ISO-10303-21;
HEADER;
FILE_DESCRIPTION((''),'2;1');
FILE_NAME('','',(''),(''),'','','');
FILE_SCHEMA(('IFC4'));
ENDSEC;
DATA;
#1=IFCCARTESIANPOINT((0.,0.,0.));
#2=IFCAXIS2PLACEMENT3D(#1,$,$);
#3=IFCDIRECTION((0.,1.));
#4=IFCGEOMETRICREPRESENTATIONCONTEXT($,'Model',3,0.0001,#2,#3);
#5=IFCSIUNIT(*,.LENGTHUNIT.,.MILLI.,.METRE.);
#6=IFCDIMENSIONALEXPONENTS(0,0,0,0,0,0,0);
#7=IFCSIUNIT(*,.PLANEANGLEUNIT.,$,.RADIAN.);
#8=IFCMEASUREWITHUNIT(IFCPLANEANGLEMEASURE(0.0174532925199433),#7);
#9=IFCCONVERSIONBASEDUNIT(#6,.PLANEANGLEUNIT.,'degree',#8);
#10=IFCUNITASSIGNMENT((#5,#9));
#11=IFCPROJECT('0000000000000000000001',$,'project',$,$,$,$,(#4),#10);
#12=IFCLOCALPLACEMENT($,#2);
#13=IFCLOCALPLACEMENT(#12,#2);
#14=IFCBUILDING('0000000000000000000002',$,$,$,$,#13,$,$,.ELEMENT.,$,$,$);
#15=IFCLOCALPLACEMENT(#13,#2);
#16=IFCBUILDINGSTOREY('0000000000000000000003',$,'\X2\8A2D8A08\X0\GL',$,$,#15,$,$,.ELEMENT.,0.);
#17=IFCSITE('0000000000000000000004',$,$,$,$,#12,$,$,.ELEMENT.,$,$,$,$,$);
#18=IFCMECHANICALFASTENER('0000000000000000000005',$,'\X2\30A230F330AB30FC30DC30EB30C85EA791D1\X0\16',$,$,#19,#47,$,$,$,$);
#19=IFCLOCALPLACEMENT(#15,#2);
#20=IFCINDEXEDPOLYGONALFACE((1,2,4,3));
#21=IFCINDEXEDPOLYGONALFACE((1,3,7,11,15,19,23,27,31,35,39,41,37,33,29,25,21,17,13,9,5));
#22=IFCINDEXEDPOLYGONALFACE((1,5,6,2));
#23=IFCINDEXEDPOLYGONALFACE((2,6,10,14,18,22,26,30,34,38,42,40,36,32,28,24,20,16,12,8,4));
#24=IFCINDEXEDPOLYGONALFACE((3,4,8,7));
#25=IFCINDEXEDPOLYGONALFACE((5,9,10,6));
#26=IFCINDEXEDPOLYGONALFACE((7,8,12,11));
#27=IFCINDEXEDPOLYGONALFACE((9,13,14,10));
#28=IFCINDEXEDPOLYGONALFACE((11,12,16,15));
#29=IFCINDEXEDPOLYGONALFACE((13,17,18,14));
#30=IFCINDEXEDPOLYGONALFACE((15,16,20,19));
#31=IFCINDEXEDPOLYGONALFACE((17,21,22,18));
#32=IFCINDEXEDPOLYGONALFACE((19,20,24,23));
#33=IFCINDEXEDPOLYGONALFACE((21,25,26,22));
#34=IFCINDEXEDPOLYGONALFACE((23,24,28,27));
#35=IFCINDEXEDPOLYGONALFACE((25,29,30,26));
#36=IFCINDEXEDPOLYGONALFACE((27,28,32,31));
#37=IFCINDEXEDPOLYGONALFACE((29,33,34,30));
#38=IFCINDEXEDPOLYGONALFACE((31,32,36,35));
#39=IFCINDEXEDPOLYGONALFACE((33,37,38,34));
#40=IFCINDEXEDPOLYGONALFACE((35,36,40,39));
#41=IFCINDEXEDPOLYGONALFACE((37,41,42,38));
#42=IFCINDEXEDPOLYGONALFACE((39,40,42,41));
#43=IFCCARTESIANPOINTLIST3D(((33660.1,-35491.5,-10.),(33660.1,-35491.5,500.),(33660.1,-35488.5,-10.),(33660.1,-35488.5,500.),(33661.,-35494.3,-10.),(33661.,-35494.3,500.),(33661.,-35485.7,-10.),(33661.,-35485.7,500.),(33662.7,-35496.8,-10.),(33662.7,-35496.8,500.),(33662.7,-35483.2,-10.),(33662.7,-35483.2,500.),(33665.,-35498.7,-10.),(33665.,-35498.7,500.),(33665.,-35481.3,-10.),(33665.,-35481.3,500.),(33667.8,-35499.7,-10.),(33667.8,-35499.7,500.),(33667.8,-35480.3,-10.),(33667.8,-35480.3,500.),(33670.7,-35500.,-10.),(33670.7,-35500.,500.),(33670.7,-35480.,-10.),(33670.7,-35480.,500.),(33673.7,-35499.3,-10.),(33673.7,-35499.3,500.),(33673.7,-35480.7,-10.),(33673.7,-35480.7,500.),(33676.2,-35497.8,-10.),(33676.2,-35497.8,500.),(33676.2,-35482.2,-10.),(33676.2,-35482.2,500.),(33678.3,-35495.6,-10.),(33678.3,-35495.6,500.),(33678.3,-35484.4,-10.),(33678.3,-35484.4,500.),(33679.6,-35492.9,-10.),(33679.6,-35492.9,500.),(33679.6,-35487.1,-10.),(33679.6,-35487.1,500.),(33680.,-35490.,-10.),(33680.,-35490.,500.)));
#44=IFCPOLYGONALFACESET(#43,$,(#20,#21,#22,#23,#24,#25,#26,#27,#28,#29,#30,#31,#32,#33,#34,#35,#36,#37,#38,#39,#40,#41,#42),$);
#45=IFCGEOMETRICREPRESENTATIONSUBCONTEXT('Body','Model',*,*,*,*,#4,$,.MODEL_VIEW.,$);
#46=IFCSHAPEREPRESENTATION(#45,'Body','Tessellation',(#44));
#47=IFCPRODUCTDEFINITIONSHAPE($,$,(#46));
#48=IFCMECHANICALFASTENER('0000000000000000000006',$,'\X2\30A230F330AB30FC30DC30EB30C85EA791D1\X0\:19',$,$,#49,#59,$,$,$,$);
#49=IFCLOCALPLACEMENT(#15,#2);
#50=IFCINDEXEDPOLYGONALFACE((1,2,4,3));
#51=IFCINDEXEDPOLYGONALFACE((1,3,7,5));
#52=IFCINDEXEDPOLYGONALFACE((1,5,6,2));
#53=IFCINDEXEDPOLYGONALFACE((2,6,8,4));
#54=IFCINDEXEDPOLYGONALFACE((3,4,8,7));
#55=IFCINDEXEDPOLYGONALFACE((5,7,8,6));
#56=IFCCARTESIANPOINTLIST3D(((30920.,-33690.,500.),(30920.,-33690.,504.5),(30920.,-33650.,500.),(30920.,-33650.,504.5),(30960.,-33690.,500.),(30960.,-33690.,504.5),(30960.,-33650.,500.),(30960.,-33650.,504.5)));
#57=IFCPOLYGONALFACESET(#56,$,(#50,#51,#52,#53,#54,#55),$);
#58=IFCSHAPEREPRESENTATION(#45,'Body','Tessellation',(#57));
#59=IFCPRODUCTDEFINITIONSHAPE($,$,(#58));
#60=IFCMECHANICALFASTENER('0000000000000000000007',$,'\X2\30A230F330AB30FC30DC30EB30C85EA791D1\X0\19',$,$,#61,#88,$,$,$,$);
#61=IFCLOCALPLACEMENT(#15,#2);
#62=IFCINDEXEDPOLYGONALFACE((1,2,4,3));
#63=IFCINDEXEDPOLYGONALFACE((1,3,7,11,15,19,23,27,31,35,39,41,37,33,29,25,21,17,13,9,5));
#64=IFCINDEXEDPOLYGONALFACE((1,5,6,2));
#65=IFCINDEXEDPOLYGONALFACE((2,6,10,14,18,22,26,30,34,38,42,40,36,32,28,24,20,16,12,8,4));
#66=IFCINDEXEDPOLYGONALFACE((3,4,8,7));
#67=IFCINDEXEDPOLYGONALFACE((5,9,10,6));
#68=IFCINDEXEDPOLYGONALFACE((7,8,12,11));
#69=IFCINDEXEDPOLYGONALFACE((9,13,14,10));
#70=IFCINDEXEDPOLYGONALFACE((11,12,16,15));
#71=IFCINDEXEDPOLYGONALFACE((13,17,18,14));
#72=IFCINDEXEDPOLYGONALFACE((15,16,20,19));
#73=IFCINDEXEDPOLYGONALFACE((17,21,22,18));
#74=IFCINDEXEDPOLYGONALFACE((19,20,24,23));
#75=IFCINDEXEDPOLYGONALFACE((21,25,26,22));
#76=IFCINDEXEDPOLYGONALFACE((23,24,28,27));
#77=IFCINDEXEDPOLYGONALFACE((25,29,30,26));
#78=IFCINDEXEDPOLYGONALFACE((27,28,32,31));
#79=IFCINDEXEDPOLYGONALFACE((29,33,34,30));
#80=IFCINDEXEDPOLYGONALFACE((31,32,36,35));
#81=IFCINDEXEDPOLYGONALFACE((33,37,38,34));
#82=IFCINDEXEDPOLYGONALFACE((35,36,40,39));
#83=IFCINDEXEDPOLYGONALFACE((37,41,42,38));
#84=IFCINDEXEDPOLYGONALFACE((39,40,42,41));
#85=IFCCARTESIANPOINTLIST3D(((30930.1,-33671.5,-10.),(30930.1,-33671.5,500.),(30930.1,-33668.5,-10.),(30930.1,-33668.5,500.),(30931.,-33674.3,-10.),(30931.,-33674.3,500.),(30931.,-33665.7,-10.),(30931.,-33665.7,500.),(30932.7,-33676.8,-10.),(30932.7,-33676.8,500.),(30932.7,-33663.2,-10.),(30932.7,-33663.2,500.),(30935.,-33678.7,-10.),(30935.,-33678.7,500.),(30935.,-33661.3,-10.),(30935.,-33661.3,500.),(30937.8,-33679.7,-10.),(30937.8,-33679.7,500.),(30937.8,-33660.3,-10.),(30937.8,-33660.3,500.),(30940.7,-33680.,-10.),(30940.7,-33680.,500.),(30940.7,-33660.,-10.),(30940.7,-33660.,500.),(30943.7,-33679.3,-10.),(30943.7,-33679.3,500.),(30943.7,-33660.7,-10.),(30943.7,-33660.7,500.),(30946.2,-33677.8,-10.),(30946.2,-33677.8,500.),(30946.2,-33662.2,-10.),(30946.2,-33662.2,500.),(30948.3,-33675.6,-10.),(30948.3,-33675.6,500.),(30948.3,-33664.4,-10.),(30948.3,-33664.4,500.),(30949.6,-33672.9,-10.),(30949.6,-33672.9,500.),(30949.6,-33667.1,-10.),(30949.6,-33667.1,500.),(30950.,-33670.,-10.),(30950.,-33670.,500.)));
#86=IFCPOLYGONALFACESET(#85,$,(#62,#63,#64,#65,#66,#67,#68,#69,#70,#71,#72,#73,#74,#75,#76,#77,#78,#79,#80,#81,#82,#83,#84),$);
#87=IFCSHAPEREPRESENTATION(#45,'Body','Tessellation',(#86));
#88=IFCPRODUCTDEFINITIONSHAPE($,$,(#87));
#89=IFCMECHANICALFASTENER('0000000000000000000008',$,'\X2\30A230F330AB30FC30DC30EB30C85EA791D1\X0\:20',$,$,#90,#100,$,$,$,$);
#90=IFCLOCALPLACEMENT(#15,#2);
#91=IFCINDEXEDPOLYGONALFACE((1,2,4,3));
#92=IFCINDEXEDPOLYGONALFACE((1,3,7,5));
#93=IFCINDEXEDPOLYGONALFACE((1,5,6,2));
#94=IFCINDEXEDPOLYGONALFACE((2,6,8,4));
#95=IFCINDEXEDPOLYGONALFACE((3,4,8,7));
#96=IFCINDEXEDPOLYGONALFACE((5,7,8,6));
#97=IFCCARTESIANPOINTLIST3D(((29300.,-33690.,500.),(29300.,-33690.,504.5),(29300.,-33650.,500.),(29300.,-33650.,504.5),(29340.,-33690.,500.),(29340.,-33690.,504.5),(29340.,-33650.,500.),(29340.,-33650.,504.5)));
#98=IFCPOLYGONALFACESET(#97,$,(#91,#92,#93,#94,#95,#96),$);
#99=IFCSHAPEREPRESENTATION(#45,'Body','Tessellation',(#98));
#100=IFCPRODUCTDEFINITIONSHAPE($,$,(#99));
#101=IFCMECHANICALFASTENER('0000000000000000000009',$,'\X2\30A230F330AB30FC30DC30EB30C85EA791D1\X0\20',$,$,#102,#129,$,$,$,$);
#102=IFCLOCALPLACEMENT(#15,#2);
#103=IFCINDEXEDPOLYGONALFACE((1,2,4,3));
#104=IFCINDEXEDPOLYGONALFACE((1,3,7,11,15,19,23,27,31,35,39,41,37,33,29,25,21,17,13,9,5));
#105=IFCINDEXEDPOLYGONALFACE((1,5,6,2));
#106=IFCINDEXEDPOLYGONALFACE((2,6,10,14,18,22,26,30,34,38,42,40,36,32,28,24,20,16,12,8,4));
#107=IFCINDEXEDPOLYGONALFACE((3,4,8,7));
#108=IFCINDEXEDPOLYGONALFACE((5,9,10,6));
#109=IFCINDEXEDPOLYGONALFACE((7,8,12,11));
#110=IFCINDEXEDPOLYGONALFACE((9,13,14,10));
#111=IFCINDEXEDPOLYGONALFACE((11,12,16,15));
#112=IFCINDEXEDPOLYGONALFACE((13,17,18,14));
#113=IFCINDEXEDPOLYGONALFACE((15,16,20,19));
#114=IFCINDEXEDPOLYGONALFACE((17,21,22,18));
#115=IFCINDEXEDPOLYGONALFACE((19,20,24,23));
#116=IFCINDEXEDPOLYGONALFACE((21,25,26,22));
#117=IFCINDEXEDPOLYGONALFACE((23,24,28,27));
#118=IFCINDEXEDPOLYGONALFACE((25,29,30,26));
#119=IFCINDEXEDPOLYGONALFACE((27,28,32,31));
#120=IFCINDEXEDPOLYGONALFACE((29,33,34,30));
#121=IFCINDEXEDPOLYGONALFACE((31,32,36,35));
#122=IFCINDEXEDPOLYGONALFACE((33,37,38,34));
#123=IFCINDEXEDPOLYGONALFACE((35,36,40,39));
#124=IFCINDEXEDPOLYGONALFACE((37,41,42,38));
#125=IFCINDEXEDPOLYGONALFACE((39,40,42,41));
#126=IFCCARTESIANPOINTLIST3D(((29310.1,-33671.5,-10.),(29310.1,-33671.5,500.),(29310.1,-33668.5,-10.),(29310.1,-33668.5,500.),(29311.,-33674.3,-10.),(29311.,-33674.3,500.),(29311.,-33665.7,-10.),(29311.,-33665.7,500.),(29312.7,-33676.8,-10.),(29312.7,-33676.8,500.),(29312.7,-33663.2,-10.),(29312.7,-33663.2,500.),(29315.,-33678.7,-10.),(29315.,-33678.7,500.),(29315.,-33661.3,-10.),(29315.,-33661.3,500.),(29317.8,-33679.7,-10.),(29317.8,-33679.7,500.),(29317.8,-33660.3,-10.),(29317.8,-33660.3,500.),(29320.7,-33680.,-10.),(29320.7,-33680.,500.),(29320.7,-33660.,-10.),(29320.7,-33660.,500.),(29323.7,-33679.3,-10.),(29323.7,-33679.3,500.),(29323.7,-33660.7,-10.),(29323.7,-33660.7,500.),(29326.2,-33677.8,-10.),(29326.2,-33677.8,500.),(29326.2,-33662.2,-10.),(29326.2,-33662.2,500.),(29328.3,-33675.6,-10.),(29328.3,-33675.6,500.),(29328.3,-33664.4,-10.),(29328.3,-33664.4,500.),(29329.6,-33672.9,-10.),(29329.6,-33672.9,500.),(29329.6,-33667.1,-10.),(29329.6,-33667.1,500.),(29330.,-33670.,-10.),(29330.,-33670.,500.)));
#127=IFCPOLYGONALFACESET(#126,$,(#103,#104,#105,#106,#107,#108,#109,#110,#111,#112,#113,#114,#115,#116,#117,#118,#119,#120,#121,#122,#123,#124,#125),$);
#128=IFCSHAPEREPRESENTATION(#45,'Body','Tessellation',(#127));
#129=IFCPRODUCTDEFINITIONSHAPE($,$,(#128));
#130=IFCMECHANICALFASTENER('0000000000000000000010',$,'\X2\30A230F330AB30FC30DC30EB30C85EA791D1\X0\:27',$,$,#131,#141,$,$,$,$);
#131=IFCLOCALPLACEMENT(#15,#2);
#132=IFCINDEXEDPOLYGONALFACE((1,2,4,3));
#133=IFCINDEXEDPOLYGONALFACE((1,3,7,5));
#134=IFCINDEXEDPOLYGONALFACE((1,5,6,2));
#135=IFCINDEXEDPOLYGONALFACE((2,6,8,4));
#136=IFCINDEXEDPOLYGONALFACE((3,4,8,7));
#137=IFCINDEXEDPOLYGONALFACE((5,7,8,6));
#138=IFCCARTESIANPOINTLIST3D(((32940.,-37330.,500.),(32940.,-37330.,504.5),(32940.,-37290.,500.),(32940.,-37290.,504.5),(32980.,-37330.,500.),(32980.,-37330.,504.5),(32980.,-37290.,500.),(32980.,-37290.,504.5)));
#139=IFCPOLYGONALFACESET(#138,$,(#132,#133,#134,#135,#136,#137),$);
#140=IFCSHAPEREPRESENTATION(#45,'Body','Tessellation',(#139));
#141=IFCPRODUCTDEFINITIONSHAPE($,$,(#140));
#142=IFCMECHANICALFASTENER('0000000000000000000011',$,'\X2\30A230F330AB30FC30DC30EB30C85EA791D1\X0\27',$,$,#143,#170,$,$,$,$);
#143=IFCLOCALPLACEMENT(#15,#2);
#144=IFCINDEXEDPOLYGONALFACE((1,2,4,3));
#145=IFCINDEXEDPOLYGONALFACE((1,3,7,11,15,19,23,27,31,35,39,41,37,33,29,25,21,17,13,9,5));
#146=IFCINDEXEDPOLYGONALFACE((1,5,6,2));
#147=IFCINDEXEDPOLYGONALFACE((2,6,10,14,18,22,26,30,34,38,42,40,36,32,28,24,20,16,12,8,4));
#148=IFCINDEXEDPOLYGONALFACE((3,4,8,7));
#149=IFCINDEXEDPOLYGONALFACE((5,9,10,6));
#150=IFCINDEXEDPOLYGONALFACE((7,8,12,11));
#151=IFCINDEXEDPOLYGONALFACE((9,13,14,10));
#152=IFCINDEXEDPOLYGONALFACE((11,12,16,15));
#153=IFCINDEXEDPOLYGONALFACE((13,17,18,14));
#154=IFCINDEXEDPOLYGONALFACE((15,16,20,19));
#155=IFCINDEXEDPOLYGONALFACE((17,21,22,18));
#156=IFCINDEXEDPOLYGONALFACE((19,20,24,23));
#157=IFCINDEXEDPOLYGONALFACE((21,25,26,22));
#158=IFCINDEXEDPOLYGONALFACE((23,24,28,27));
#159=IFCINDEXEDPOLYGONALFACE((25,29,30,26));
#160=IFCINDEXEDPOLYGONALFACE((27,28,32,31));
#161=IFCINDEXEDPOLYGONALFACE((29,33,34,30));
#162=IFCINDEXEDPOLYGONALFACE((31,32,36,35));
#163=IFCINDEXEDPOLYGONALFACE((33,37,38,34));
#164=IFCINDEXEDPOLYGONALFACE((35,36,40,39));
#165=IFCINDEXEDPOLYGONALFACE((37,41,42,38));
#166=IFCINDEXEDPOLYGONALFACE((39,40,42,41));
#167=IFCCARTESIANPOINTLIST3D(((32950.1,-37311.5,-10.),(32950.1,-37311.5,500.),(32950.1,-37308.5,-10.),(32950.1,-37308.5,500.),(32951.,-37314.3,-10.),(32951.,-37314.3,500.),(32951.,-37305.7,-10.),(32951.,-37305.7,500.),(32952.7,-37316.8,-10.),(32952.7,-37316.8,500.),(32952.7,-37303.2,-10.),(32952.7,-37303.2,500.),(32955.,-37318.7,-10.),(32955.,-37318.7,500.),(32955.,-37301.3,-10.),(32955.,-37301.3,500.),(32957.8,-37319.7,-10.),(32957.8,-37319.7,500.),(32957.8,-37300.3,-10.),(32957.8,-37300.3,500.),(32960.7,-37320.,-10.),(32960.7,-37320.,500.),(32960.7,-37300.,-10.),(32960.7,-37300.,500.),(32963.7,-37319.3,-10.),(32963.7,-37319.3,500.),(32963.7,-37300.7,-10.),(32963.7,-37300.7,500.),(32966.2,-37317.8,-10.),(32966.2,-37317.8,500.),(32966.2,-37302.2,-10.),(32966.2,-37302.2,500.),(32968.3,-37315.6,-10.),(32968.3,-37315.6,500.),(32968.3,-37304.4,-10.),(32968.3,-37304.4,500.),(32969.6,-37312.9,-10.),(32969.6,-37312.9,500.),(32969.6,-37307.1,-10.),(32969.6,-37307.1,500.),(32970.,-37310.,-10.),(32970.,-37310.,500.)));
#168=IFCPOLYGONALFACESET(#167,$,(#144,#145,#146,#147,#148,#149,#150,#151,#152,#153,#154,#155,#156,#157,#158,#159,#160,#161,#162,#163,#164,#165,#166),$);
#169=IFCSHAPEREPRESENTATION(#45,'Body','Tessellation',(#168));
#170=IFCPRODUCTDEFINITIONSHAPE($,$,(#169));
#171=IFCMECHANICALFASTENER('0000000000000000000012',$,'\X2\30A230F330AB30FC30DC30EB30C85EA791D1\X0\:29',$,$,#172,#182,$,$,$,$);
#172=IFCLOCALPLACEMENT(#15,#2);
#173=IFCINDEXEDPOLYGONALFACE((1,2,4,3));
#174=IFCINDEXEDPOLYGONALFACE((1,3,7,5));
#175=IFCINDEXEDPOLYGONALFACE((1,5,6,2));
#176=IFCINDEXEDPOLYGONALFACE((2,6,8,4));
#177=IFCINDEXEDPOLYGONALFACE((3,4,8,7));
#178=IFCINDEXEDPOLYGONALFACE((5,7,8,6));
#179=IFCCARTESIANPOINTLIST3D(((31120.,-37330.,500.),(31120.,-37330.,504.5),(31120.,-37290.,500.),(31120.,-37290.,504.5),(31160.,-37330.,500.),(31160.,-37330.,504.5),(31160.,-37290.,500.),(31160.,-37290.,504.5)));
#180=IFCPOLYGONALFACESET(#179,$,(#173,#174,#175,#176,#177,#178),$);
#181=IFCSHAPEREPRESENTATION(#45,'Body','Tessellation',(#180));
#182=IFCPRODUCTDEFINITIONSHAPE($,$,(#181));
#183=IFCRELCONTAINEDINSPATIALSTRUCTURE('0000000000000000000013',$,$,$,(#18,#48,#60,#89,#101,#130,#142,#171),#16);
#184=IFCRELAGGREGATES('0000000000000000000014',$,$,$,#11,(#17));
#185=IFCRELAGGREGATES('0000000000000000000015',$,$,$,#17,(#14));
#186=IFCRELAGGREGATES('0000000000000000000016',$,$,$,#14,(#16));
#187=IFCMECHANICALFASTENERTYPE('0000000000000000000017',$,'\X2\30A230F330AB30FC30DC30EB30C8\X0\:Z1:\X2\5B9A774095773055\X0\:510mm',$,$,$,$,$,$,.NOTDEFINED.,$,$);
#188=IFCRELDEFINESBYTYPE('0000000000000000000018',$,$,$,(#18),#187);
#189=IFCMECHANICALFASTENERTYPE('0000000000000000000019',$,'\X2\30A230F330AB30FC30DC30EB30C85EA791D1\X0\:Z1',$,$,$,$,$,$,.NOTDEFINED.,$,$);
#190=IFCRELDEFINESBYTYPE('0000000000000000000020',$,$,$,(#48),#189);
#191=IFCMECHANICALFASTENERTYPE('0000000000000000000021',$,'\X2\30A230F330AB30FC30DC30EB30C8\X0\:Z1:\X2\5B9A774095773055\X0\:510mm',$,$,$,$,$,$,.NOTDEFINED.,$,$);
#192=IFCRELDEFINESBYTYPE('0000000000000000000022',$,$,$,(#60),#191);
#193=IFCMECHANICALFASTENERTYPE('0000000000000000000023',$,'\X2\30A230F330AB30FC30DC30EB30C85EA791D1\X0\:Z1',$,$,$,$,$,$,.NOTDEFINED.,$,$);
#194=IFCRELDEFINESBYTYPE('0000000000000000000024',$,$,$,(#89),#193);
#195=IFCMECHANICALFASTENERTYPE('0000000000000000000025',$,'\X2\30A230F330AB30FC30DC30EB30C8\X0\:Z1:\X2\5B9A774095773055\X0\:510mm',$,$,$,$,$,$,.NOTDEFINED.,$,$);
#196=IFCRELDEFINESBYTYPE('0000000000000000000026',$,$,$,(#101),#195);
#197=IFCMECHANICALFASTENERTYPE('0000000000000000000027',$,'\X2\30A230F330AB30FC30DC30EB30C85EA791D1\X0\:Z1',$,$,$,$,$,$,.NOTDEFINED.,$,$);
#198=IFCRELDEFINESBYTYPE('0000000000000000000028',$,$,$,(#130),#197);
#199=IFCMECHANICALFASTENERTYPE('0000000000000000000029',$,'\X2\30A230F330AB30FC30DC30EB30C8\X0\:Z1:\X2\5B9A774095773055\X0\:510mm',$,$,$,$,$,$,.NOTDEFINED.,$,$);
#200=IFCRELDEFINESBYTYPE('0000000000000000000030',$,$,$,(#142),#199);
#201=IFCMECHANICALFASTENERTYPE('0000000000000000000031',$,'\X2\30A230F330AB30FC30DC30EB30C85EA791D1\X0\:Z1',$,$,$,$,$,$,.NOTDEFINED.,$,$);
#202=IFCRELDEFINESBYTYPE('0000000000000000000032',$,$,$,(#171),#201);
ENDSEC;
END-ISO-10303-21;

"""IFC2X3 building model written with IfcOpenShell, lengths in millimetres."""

from ifc_helpers import new_model, entity, si_unit, converted_unit, direction, frame, origin, origin_with_axes, origin_2d, place, context, subcontext, project, spatial, rectangle, circle, extrude, type_object, element, save


model = new_model("IFC2X3")

# Units and contexts
model_context = context("Model", 3, precision=0.0001, world=origin(), true_north=direction((0.0, 1.0)))
body_context = subcontext(model_context, "Body", "Model", "MODEL_VIEW")
ifc_project = project(units=[si_unit("LENGTHUNIT", "METRE", prefix="MILLI"), converted_unit("PLANEANGLEUNIT", "degree", entity("IfcPlaneAngleMeasure", 0.0174532925199433), si_unit("PLANEANGLEUNIT", "RADIAN"), dimensions=[0, 0, 0, 0, 0, 0, 0])], contexts=[model_context])

# Site, building, storey
site_placement = place(None, origin())
site = spatial("IfcSite", under=ifc_project, at=site_placement, CompositionType="ELEMENT")
building_placement = place(site_placement, origin())
building = spatial("IfcBuilding", under=site, at=building_placement, CompositionType="ELEMENT")
storey_placement = place(building_placement, origin())
storey = spatial("IfcBuildingStorey", under=building, at=storey_placement, Name="設計GL", CompositionType="ELEMENT", Elevation=0.0)

# Mechanical fasteners
mechanical_fastener_type_1 = type_object("IfcMechanicalFastenerType", Name="アンカーボルト:Z1:定着長さ:510mm")
mechanical_fastener_1_placement = place(storey_placement, frame((33670.0, -35490.0, -10.0)))
element("IfcMechanicalFastener", 1, at=mechanical_fastener_1_placement, inside=storey, type_object=mechanical_fastener_type_1, Name="アンカーボルト座金16", context=body_context, shape_type="SweptSolid", body=[
    extrude(circle(Radius=10.0, at=origin_2d()), origin_with_axes(), (0.0, 0.0, 1.0), 510.0),
])
mechanical_fastener_type_2 = type_object("IfcMechanicalFastenerType", Name="アンカーボルト座金:Z1")
mechanical_fastener_2_placement = place(storey_placement, frame((30940.0, -33670.0, 500.0)))
element("IfcMechanicalFastener", 2, at=mechanical_fastener_2_placement, inside=storey, type_object=mechanical_fastener_type_2, Name="アンカーボルト座金:19", context=body_context, shape_type="SweptSolid", body=[
    extrude(rectangle(XDim=40.0, YDim=40.0, at=origin_2d()), origin_with_axes(), (0.0, 0.0, 1.0), 4.5),
])
mechanical_fastener_type_3 = type_object("IfcMechanicalFastenerType", Name="アンカーボルト:Z1:定着長さ:510mm")
mechanical_fastener_3_placement = place(storey_placement, frame((30940.0, -33670.0, -10.0)))
element("IfcMechanicalFastener", 3, at=mechanical_fastener_3_placement, inside=storey, type_object=mechanical_fastener_type_3, Name="アンカーボルト座金19", context=body_context, shape_type="SweptSolid", body=[
    extrude(circle(Radius=10.0, at=origin_2d()), origin_with_axes(), (0.0, 0.0, 1.0), 510.0),
])
mechanical_fastener_type_4 = type_object("IfcMechanicalFastenerType", Name="アンカーボルト座金:Z1")
mechanical_fastener_4_placement = place(storey_placement, frame((29320.0, -33670.0, 500.0)))
element("IfcMechanicalFastener", 4, at=mechanical_fastener_4_placement, inside=storey, type_object=mechanical_fastener_type_4, Name="アンカーボルト座金:20", context=body_context, shape_type="SweptSolid", body=[
    extrude(rectangle(XDim=40.0, YDim=40.0, at=origin_2d()), origin_with_axes(), (0.0, 0.0, 1.0), 4.5),
])
mechanical_fastener_type_5 = type_object("IfcMechanicalFastenerType", Name="アンカーボルト:Z1:定着長さ:510mm")
mechanical_fastener_5_placement = place(storey_placement, frame((29320.0, -33670.0, -10.0)))
element("IfcMechanicalFastener", 5, at=mechanical_fastener_5_placement, inside=storey, type_object=mechanical_fastener_type_5, Name="アンカーボルト座金20", context=body_context, shape_type="SweptSolid", body=[
    extrude(circle(Radius=10.0, at=origin_2d()), origin_with_axes(), (0.0, 0.0, 1.0), 510.0),
])
mechanical_fastener_type_6 = type_object("IfcMechanicalFastenerType", Name="アンカーボルト座金:Z1")
mechanical_fastener_6_placement = place(storey_placement, frame((32960.0, -37310.0, 500.0)))
element("IfcMechanicalFastener", 6, at=mechanical_fastener_6_placement, inside=storey, type_object=mechanical_fastener_type_6, Name="アンカーボルト座金:27", context=body_context, shape_type="SweptSolid", body=[
    extrude(rectangle(XDim=40.0, YDim=40.0, at=origin_2d()), origin_with_axes(), (0.0, 0.0, 1.0), 4.5),
])
mechanical_fastener_type_7 = type_object("IfcMechanicalFastenerType", Name="アンカーボルト:Z1:定着長さ:510mm")
mechanical_fastener_7_placement = place(storey_placement, frame((32960.0, -37310.0, -10.0)))
element("IfcMechanicalFastener", 7, at=mechanical_fastener_7_placement, inside=storey, type_object=mechanical_fastener_type_7, Name="アンカーボルト座金27", context=body_context, shape_type="SweptSolid", body=[
    extrude(circle(Radius=10.0, at=origin_2d()), origin_with_axes(), (0.0, 0.0, 1.0), 510.0),
])
mechanical_fastener_type_8 = type_object("IfcMechanicalFastenerType", Name="アンカーボルト座金:Z1")
mechanical_fastener_8_placement = place(storey_placement, frame((31140.0, -37310.0, 500.0)))
element("IfcMechanicalFastener", 8, at=mechanical_fastener_8_placement, inside=storey, type_object=mechanical_fastener_type_8, Name="アンカーボルト座金:29", context=body_context, shape_type="SweptSolid", body=[
    extrude(rectangle(XDim=40.0, YDim=40.0, at=origin_2d()), origin_with_axes(), (0.0, 0.0, 1.0), 4.5),
])

save(model, "model.ifc")
